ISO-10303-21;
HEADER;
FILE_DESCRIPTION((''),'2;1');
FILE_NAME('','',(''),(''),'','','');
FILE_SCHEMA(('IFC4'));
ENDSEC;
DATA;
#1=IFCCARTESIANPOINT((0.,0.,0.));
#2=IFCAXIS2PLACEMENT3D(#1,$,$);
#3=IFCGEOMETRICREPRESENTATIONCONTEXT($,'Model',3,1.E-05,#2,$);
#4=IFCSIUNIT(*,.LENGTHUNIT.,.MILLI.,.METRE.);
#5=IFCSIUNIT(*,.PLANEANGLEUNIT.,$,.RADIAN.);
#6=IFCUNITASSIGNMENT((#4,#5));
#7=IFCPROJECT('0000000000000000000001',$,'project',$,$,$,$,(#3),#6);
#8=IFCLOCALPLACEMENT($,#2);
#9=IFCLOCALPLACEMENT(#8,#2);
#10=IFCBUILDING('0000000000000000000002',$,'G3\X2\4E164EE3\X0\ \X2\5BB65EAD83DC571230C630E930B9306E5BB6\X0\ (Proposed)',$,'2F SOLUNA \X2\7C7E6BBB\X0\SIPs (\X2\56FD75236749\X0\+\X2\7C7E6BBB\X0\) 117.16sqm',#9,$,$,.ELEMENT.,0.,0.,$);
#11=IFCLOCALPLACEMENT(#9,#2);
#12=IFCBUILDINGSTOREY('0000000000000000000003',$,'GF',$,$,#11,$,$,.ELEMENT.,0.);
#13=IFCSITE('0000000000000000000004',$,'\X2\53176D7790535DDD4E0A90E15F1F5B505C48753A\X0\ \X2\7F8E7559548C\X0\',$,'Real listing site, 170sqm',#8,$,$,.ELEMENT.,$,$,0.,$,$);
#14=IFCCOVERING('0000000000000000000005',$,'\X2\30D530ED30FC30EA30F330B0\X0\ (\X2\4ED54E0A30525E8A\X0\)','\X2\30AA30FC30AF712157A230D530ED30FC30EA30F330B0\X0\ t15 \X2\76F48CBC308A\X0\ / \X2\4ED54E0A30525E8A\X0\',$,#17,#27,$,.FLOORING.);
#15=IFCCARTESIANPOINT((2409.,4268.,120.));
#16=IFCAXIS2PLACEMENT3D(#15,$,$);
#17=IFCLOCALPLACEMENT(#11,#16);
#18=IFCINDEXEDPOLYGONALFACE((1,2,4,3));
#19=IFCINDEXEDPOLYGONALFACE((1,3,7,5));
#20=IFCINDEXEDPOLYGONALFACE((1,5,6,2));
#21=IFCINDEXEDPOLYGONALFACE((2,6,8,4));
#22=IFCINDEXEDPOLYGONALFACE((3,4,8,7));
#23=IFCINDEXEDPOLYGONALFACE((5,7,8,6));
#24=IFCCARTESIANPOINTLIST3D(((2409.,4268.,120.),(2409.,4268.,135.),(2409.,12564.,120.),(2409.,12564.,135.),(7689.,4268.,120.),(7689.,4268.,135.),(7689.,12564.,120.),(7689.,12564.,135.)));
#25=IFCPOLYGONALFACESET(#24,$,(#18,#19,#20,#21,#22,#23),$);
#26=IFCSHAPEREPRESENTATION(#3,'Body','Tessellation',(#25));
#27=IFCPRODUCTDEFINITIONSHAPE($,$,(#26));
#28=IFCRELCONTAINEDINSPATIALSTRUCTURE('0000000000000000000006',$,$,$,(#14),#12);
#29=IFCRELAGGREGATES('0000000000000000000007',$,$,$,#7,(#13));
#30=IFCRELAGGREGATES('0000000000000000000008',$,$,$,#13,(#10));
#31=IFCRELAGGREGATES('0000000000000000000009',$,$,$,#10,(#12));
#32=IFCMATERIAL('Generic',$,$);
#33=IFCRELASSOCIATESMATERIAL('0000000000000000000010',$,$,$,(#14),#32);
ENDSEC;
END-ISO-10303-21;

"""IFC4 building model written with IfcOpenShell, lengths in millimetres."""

from ifc_helpers import new_model, si_unit, frame, frame_2d, origin, place, context, project, spatial, rectangle, extrude, material, element, save


model = new_model("IFC4")

# Units and contexts
model_context = context("Model", 3, precision=1e-05, world=origin())
ifc_project = project(units=[si_unit("LENGTHUNIT", "METRE", prefix="MILLI"), si_unit("PLANEANGLEUNIT", "RADIAN")], contexts=[model_context])

# Site, building, storey
site_placement = place(None, origin())
site = spatial("IfcSite", under=ifc_project, at=site_placement, Name="北海道川上郡弟子屈町 美留和", ObjectType="Real listing site, 170sqm", CompositionType="ELEMENT", RefElevation=0.0)
building_placement = place(site_placement, origin())
building = spatial("IfcBuilding", under=site, at=building_placement, Name="G3世代 家庭菜園テラスの家 (Proposed)", ObjectType="2F SOLUNA 籾殻SIPs (国産杉+籾殻) 117.16sqm", CompositionType="ELEMENT", ElevationOfRefHeight=0.0, ElevationOfTerrain=0.0)
storey_placement = place(building_placement, origin())
storey = spatial("IfcBuildingStorey", under=building, at=storey_placement, Name="GF", CompositionType="ELEMENT", Elevation=0.0)

# Shared definitions
ifc_material_1 = material(Name="Generic")

# Covering
covering_placement = place(storey_placement, frame((2409.0, 4268.0, 120.0)))
element("IfcCovering", 1, at=covering_placement, inside=storey, material=ifc_material_1, Name="フローリング (仕上げ床)", Description="オーク無垢フローリング t15 直貼り / 仕上げ床", PredefinedType="FLOORING", context=model_context, shape_type="SweptSolid", body=[
    extrude(rectangle(XDim=5280.0, YDim=8296.0, at=frame_2d((2640.0, 4148.0))), frame((2409.0, 4268.0, 120.0)), (0.0, 0.0, 1.0), 15.0),
])

save(model, "model.ifc")
